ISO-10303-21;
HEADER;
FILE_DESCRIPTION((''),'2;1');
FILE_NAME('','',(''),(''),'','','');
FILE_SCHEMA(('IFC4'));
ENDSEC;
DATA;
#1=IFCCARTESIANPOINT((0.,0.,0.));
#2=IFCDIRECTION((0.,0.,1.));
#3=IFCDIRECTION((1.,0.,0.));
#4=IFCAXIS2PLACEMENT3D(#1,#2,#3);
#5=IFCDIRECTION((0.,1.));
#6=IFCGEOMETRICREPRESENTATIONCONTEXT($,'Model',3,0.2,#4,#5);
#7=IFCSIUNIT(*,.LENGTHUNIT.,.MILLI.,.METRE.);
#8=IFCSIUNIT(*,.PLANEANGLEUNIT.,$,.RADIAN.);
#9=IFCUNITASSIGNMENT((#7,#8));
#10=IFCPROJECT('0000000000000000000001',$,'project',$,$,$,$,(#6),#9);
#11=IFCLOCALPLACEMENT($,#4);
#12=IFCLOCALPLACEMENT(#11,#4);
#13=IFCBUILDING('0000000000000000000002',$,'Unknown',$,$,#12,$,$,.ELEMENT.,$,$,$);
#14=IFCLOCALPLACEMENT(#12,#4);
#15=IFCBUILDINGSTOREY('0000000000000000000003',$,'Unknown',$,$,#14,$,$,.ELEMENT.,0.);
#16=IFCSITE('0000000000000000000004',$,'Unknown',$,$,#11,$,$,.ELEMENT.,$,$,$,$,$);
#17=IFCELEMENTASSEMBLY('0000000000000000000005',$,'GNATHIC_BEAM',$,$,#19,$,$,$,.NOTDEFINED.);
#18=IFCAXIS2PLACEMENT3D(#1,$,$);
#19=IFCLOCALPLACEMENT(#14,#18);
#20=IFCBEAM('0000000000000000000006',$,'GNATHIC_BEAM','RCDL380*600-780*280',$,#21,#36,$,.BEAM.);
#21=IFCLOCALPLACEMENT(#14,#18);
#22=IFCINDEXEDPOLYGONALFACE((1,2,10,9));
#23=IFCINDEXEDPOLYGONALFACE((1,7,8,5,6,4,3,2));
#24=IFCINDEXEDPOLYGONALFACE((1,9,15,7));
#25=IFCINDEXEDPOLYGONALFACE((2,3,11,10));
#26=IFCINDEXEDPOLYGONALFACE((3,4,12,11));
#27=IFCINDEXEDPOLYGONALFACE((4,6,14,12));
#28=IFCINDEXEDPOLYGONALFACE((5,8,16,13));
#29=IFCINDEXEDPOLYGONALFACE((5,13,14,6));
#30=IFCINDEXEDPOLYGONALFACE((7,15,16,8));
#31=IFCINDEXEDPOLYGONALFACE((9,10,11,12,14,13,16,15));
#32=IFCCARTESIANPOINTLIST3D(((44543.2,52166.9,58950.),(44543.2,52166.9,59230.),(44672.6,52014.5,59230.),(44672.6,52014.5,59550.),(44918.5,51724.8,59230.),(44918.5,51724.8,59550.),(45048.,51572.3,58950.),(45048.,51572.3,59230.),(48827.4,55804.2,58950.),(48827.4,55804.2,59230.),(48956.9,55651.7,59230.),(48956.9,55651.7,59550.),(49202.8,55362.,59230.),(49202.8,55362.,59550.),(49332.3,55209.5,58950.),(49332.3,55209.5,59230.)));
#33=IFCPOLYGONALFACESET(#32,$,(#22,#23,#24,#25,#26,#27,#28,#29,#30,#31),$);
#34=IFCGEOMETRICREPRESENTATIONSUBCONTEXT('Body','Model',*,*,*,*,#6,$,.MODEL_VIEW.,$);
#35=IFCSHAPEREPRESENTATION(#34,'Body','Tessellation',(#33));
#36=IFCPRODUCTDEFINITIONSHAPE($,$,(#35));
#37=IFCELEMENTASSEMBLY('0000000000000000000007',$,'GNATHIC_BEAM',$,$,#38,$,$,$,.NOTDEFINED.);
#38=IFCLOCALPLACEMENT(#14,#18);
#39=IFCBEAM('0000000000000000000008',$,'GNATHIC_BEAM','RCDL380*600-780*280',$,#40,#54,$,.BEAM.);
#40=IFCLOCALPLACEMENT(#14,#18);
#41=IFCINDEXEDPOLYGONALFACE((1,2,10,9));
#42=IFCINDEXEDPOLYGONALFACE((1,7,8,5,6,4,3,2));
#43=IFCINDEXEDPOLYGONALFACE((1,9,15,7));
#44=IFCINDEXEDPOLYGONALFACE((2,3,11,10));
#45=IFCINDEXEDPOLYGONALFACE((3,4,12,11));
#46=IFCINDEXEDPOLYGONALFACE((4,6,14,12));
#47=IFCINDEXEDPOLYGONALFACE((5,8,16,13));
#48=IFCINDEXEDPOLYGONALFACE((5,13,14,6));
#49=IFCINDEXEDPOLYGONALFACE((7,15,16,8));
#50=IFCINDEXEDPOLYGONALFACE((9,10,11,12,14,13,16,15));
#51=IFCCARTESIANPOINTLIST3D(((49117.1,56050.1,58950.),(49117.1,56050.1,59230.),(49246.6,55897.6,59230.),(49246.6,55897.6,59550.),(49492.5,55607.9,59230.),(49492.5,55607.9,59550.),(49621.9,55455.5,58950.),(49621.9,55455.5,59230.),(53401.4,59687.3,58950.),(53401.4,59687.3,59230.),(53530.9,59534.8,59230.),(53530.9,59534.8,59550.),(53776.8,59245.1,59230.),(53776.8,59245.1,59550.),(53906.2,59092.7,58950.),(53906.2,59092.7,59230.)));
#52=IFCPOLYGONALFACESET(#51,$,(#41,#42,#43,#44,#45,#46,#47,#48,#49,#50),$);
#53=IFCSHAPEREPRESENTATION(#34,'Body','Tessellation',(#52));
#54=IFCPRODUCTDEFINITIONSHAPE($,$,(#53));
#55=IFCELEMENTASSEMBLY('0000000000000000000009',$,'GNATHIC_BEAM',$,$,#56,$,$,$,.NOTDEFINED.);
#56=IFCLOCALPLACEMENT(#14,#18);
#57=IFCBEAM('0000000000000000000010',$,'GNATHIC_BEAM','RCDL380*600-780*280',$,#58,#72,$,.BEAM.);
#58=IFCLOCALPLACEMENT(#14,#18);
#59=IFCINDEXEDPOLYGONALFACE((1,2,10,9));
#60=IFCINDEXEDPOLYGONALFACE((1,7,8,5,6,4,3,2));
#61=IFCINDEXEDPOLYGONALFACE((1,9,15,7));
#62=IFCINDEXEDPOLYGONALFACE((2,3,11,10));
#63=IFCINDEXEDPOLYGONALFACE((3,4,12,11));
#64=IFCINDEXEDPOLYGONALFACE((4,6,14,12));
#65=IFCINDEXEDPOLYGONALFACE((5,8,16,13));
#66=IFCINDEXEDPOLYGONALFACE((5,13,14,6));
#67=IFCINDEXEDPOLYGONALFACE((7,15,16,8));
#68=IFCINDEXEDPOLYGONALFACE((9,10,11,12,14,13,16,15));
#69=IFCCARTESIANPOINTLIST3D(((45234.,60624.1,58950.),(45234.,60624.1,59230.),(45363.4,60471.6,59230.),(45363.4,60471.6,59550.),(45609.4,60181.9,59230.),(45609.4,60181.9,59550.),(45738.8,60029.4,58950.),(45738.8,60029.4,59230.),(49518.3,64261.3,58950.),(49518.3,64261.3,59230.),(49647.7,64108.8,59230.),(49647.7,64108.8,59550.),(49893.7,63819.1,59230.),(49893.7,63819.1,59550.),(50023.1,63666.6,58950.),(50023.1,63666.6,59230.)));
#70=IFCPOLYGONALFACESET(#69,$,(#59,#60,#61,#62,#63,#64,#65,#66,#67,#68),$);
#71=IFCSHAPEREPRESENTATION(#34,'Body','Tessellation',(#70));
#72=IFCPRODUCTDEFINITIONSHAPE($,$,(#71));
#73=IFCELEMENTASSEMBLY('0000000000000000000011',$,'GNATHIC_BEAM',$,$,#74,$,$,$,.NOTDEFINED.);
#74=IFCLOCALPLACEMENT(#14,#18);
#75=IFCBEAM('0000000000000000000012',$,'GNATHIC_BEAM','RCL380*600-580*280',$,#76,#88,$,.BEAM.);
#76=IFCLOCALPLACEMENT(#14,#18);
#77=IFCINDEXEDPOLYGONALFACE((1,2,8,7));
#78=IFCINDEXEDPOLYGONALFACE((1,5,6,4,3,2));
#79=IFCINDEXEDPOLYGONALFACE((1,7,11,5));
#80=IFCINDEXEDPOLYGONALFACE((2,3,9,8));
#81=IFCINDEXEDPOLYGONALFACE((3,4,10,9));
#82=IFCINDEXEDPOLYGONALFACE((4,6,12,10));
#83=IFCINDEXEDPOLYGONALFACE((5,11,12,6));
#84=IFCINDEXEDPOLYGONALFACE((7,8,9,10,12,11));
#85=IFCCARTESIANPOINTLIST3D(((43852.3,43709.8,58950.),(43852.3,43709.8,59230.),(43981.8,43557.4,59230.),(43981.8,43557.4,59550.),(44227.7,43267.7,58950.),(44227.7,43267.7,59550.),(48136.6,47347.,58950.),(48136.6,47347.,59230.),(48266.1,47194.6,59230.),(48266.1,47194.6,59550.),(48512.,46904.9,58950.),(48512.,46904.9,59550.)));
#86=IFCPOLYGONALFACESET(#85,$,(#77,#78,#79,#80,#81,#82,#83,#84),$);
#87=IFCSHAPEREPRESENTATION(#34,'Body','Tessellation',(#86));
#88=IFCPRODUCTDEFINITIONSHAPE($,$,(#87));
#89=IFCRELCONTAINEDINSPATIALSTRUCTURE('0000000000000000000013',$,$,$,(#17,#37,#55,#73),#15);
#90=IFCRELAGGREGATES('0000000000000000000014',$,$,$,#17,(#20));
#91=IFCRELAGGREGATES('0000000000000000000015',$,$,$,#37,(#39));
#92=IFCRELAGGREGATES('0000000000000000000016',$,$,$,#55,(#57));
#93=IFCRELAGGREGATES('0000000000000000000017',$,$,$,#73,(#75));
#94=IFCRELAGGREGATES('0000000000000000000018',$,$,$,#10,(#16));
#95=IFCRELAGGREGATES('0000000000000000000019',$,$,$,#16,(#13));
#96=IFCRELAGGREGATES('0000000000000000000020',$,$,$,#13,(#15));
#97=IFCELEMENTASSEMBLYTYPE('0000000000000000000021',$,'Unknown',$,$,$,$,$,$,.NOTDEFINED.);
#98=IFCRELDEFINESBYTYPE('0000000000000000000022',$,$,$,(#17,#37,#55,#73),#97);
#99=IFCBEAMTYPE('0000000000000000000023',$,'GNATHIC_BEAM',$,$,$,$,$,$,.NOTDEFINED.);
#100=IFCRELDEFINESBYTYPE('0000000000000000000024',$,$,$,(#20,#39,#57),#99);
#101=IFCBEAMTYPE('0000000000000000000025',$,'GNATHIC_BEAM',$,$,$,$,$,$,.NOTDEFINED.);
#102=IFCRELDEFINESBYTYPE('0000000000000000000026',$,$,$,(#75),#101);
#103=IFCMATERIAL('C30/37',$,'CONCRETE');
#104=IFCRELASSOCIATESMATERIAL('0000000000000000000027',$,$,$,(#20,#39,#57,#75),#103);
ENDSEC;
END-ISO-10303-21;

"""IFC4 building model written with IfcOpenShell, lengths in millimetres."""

from ifc_helpers import new_model, si_unit, direction, frame, origin_with_axes, place, context, subcontext, project, spatial, polyline, outline, extrude, material, material_profile, profile_set, profile_usage, type_object, element, aggregate, save


model = new_model("IFC4")

# Units and contexts
model_context = context("Model", 3, precision=0.2, world=origin_with_axes(), true_north=direction((0.0, 1.0)))
body_context = subcontext(model_context, "Body", "Model", "MODEL_VIEW")
ifc_project = project(units=[si_unit("LENGTHUNIT", "METRE", prefix="MILLI"), si_unit("PLANEANGLEUNIT", "RADIAN")], contexts=[model_context])

# Site, building, storey
site_placement = place(None, origin_with_axes())
site = spatial("IfcSite", under=ifc_project, at=site_placement, Name="Unknown", CompositionType="ELEMENT")
building_placement = place(site_placement, origin_with_axes())
building = spatial("IfcBuilding", under=site, at=building_placement, Name="Unknown", CompositionType="ELEMENT")
storey_placement = place(building_placement, origin_with_axes())
storey = spatial("IfcBuildingStorey", under=building, at=storey_placement, Name="Unknown", CompositionType="ELEMENT", Elevation=0.0)

# Shared definitions
element_assembly_type = type_object("IfcElementAssemblyType", Name="Unknown", PredefinedType="NOTDEFINED")

# Element assemblies, beams
ifc_material_1 = material(Name="C30/37", Category="CONCRETE")
ifc_material_profile_1 = material_profile(ifc_material_1, outline(polyline([(-390.0, -300.0), (390.0, -300.0), (390.0, -20.0), (190.0, -20.0), (190.0, 300.0), (-190.0, 300.0), (-190.0, -20.0), (-390.0, -20.0), (-390.0, -300.0)])), Name="RCDL380*600-780*280")
ifc_profile_set_1 = profile_set([ifc_material_profile_1])
ifc_profile_usage_1 = profile_usage(ifc_profile_set_1, cardinal=2)
beam_type_1 = type_object("IfcBeamType", Name="GNATHIC_BEAM")
assembly_1_placement = place(storey_placement, frame((44795.6, 51869.6, 59250.0), z_axis=(0.64719, -0.762329, 0.0), x_axis=(0.762329, 0.64719, 0.0)))
assembly_1 = element("IfcElementAssembly", 1, at=assembly_1_placement, inside=storey, type_object=element_assembly_type, Name="GNATHIC_BEAM", PredefinedType="NOTDEFINED")
beam_1_placement = place(assembly_1_placement, origin_with_axes())
beam_1 = element("IfcBeam", 2, at=beam_1_placement, type_object=beam_type_1, material=ifc_profile_usage_1, Name="GNATHIC_BEAM", Description="RCDL380*600-780*280", PredefinedType="BEAM", context=body_context, shape_type="SolidModel", body=[
    extrude(outline(polyline([(-390.0, -300.0), (390.0, -300.0), (390.0, -20.0), (190.0, -20.0), (190.0, 300.0), (-190.0, 300.0), (-190.0, -20.0), (-390.0, -20.0), (-390.0, -300.0)])), frame((0.0, 0.0, 0.0), z_axis=(-1.0, 0.0, 0.0), x_axis=(0.0, 0.0, 1.0)), (0.0, 0.0, -1.0), 5620.0),
])
aggregate(assembly_1, [beam_1])
assembly_2_placement = place(storey_placement, frame((49369.5, 55752.8, 59250.0), z_axis=(0.64719, -0.762329, 0.0), x_axis=(0.762329, 0.64719, 0.0)))
assembly_2 = element("IfcElementAssembly", 3, at=assembly_2_placement, inside=storey, type_object=element_assembly_type, Name="GNATHIC_BEAM", PredefinedType="NOTDEFINED")
beam_2_placement = place(assembly_2_placement, origin_with_axes())
beam_2 = element("IfcBeam", 4, at=beam_2_placement, type_object=beam_type_1, material=ifc_profile_usage_1, Name="GNATHIC_BEAM", Description="RCDL380*600-780*280", PredefinedType="BEAM", context=body_context, shape_type="SolidModel", body=[
    extrude(outline(polyline([(-390.0, -300.0), (390.0, -300.0), (390.0, -20.0), (190.0, -20.0), (190.0, 300.0), (-190.0, 300.0), (-190.0, -20.0), (-390.0, -20.0), (-390.0, -300.0)])), frame((0.0, 0.0, 0.0), z_axis=(-1.0, 0.0, 0.0), x_axis=(0.0, 0.0, 1.0)), (0.0, 0.0, -1.0), 5620.0),
])
aggregate(assembly_2, [beam_2])
assembly_3_placement = place(storey_placement, frame((45486.4, 60326.7, 59250.0), z_axis=(0.64719, -0.762329, 0.0), x_axis=(0.762329, 0.64719, 0.0)))
assembly_3 = element("IfcElementAssembly", 5, at=assembly_3_placement, inside=storey, type_object=element_assembly_type, Name="GNATHIC_BEAM", PredefinedType="NOTDEFINED")
beam_3_placement = place(assembly_3_placement, origin_with_axes())
beam_3 = element("IfcBeam", 6, at=beam_3_placement, type_object=beam_type_1, material=ifc_profile_usage_1, Name="GNATHIC_BEAM", Description="RCDL380*600-780*280", PredefinedType="BEAM", context=body_context, shape_type="SolidModel", body=[
    extrude(outline(polyline([(-390.0, -300.0), (390.0, -300.0), (390.0, -20.0), (190.0, -20.0), (190.0, 300.0), (-190.0, 300.0), (-190.0, -20.0), (-390.0, -20.0), (-390.0, -300.0)])), frame((0.0, 0.0, 0.0), z_axis=(-1.0, 0.0, 0.0), x_axis=(0.0, 0.0, 1.0)), (0.0, 0.0, -1.0), 5620.0),
])
aggregate(assembly_3, [beam_3])
assembly_4_placement = place(storey_placement, frame((48389.0, 47049.7, 59250.0), z_axis=(-0.64719, 0.762329, 0.0), x_axis=(-0.762329, -0.64719, 0.0)))
assembly_4 = element("IfcElementAssembly", 7, at=assembly_4_placement, inside=storey, type_object=element_assembly_type, Name="GNATHIC_BEAM", PredefinedType="NOTDEFINED")
ifc_material_profile_2 = material_profile(ifc_material_1, outline(polyline([(-190.0, -300.0), (390.0, -300.0), (390.0, -20.0), (190.0, -20.0), (190.0, 300.0), (-190.0, 300.0), (-190.0, -300.0)])), Name="RCL380*600-580*280")
ifc_profile_set_2 = profile_set([ifc_material_profile_2])
ifc_profile_usage_2 = profile_usage(ifc_profile_set_2, cardinal=2)
beam_type_2 = type_object("IfcBeamType", Name="GNATHIC_BEAM")
beam_4_placement = place(assembly_4_placement, origin_with_axes())
beam_4 = element("IfcBeam", 8, at=beam_4_placement, type_object=beam_type_2, material=ifc_profile_usage_2, Name="GNATHIC_BEAM", Description="RCL380*600-580*280", PredefinedType="BEAM", context=body_context, shape_type="SolidModel", body=[
    extrude(outline(polyline([(-190.0, -300.0), (390.0, -300.0), (390.0, -20.0), (190.0, -20.0), (190.0, 300.0), (-190.0, 300.0), (-190.0, -300.0)])), frame((0.0, 0.0, 0.0), z_axis=(-1.0, 0.0, 0.0), x_axis=(0.0, 0.0, 1.0)), (0.0, 0.0, -1.0), 5620.0),
])
aggregate(assembly_4, [beam_4])

save(model, "model.ifc")
